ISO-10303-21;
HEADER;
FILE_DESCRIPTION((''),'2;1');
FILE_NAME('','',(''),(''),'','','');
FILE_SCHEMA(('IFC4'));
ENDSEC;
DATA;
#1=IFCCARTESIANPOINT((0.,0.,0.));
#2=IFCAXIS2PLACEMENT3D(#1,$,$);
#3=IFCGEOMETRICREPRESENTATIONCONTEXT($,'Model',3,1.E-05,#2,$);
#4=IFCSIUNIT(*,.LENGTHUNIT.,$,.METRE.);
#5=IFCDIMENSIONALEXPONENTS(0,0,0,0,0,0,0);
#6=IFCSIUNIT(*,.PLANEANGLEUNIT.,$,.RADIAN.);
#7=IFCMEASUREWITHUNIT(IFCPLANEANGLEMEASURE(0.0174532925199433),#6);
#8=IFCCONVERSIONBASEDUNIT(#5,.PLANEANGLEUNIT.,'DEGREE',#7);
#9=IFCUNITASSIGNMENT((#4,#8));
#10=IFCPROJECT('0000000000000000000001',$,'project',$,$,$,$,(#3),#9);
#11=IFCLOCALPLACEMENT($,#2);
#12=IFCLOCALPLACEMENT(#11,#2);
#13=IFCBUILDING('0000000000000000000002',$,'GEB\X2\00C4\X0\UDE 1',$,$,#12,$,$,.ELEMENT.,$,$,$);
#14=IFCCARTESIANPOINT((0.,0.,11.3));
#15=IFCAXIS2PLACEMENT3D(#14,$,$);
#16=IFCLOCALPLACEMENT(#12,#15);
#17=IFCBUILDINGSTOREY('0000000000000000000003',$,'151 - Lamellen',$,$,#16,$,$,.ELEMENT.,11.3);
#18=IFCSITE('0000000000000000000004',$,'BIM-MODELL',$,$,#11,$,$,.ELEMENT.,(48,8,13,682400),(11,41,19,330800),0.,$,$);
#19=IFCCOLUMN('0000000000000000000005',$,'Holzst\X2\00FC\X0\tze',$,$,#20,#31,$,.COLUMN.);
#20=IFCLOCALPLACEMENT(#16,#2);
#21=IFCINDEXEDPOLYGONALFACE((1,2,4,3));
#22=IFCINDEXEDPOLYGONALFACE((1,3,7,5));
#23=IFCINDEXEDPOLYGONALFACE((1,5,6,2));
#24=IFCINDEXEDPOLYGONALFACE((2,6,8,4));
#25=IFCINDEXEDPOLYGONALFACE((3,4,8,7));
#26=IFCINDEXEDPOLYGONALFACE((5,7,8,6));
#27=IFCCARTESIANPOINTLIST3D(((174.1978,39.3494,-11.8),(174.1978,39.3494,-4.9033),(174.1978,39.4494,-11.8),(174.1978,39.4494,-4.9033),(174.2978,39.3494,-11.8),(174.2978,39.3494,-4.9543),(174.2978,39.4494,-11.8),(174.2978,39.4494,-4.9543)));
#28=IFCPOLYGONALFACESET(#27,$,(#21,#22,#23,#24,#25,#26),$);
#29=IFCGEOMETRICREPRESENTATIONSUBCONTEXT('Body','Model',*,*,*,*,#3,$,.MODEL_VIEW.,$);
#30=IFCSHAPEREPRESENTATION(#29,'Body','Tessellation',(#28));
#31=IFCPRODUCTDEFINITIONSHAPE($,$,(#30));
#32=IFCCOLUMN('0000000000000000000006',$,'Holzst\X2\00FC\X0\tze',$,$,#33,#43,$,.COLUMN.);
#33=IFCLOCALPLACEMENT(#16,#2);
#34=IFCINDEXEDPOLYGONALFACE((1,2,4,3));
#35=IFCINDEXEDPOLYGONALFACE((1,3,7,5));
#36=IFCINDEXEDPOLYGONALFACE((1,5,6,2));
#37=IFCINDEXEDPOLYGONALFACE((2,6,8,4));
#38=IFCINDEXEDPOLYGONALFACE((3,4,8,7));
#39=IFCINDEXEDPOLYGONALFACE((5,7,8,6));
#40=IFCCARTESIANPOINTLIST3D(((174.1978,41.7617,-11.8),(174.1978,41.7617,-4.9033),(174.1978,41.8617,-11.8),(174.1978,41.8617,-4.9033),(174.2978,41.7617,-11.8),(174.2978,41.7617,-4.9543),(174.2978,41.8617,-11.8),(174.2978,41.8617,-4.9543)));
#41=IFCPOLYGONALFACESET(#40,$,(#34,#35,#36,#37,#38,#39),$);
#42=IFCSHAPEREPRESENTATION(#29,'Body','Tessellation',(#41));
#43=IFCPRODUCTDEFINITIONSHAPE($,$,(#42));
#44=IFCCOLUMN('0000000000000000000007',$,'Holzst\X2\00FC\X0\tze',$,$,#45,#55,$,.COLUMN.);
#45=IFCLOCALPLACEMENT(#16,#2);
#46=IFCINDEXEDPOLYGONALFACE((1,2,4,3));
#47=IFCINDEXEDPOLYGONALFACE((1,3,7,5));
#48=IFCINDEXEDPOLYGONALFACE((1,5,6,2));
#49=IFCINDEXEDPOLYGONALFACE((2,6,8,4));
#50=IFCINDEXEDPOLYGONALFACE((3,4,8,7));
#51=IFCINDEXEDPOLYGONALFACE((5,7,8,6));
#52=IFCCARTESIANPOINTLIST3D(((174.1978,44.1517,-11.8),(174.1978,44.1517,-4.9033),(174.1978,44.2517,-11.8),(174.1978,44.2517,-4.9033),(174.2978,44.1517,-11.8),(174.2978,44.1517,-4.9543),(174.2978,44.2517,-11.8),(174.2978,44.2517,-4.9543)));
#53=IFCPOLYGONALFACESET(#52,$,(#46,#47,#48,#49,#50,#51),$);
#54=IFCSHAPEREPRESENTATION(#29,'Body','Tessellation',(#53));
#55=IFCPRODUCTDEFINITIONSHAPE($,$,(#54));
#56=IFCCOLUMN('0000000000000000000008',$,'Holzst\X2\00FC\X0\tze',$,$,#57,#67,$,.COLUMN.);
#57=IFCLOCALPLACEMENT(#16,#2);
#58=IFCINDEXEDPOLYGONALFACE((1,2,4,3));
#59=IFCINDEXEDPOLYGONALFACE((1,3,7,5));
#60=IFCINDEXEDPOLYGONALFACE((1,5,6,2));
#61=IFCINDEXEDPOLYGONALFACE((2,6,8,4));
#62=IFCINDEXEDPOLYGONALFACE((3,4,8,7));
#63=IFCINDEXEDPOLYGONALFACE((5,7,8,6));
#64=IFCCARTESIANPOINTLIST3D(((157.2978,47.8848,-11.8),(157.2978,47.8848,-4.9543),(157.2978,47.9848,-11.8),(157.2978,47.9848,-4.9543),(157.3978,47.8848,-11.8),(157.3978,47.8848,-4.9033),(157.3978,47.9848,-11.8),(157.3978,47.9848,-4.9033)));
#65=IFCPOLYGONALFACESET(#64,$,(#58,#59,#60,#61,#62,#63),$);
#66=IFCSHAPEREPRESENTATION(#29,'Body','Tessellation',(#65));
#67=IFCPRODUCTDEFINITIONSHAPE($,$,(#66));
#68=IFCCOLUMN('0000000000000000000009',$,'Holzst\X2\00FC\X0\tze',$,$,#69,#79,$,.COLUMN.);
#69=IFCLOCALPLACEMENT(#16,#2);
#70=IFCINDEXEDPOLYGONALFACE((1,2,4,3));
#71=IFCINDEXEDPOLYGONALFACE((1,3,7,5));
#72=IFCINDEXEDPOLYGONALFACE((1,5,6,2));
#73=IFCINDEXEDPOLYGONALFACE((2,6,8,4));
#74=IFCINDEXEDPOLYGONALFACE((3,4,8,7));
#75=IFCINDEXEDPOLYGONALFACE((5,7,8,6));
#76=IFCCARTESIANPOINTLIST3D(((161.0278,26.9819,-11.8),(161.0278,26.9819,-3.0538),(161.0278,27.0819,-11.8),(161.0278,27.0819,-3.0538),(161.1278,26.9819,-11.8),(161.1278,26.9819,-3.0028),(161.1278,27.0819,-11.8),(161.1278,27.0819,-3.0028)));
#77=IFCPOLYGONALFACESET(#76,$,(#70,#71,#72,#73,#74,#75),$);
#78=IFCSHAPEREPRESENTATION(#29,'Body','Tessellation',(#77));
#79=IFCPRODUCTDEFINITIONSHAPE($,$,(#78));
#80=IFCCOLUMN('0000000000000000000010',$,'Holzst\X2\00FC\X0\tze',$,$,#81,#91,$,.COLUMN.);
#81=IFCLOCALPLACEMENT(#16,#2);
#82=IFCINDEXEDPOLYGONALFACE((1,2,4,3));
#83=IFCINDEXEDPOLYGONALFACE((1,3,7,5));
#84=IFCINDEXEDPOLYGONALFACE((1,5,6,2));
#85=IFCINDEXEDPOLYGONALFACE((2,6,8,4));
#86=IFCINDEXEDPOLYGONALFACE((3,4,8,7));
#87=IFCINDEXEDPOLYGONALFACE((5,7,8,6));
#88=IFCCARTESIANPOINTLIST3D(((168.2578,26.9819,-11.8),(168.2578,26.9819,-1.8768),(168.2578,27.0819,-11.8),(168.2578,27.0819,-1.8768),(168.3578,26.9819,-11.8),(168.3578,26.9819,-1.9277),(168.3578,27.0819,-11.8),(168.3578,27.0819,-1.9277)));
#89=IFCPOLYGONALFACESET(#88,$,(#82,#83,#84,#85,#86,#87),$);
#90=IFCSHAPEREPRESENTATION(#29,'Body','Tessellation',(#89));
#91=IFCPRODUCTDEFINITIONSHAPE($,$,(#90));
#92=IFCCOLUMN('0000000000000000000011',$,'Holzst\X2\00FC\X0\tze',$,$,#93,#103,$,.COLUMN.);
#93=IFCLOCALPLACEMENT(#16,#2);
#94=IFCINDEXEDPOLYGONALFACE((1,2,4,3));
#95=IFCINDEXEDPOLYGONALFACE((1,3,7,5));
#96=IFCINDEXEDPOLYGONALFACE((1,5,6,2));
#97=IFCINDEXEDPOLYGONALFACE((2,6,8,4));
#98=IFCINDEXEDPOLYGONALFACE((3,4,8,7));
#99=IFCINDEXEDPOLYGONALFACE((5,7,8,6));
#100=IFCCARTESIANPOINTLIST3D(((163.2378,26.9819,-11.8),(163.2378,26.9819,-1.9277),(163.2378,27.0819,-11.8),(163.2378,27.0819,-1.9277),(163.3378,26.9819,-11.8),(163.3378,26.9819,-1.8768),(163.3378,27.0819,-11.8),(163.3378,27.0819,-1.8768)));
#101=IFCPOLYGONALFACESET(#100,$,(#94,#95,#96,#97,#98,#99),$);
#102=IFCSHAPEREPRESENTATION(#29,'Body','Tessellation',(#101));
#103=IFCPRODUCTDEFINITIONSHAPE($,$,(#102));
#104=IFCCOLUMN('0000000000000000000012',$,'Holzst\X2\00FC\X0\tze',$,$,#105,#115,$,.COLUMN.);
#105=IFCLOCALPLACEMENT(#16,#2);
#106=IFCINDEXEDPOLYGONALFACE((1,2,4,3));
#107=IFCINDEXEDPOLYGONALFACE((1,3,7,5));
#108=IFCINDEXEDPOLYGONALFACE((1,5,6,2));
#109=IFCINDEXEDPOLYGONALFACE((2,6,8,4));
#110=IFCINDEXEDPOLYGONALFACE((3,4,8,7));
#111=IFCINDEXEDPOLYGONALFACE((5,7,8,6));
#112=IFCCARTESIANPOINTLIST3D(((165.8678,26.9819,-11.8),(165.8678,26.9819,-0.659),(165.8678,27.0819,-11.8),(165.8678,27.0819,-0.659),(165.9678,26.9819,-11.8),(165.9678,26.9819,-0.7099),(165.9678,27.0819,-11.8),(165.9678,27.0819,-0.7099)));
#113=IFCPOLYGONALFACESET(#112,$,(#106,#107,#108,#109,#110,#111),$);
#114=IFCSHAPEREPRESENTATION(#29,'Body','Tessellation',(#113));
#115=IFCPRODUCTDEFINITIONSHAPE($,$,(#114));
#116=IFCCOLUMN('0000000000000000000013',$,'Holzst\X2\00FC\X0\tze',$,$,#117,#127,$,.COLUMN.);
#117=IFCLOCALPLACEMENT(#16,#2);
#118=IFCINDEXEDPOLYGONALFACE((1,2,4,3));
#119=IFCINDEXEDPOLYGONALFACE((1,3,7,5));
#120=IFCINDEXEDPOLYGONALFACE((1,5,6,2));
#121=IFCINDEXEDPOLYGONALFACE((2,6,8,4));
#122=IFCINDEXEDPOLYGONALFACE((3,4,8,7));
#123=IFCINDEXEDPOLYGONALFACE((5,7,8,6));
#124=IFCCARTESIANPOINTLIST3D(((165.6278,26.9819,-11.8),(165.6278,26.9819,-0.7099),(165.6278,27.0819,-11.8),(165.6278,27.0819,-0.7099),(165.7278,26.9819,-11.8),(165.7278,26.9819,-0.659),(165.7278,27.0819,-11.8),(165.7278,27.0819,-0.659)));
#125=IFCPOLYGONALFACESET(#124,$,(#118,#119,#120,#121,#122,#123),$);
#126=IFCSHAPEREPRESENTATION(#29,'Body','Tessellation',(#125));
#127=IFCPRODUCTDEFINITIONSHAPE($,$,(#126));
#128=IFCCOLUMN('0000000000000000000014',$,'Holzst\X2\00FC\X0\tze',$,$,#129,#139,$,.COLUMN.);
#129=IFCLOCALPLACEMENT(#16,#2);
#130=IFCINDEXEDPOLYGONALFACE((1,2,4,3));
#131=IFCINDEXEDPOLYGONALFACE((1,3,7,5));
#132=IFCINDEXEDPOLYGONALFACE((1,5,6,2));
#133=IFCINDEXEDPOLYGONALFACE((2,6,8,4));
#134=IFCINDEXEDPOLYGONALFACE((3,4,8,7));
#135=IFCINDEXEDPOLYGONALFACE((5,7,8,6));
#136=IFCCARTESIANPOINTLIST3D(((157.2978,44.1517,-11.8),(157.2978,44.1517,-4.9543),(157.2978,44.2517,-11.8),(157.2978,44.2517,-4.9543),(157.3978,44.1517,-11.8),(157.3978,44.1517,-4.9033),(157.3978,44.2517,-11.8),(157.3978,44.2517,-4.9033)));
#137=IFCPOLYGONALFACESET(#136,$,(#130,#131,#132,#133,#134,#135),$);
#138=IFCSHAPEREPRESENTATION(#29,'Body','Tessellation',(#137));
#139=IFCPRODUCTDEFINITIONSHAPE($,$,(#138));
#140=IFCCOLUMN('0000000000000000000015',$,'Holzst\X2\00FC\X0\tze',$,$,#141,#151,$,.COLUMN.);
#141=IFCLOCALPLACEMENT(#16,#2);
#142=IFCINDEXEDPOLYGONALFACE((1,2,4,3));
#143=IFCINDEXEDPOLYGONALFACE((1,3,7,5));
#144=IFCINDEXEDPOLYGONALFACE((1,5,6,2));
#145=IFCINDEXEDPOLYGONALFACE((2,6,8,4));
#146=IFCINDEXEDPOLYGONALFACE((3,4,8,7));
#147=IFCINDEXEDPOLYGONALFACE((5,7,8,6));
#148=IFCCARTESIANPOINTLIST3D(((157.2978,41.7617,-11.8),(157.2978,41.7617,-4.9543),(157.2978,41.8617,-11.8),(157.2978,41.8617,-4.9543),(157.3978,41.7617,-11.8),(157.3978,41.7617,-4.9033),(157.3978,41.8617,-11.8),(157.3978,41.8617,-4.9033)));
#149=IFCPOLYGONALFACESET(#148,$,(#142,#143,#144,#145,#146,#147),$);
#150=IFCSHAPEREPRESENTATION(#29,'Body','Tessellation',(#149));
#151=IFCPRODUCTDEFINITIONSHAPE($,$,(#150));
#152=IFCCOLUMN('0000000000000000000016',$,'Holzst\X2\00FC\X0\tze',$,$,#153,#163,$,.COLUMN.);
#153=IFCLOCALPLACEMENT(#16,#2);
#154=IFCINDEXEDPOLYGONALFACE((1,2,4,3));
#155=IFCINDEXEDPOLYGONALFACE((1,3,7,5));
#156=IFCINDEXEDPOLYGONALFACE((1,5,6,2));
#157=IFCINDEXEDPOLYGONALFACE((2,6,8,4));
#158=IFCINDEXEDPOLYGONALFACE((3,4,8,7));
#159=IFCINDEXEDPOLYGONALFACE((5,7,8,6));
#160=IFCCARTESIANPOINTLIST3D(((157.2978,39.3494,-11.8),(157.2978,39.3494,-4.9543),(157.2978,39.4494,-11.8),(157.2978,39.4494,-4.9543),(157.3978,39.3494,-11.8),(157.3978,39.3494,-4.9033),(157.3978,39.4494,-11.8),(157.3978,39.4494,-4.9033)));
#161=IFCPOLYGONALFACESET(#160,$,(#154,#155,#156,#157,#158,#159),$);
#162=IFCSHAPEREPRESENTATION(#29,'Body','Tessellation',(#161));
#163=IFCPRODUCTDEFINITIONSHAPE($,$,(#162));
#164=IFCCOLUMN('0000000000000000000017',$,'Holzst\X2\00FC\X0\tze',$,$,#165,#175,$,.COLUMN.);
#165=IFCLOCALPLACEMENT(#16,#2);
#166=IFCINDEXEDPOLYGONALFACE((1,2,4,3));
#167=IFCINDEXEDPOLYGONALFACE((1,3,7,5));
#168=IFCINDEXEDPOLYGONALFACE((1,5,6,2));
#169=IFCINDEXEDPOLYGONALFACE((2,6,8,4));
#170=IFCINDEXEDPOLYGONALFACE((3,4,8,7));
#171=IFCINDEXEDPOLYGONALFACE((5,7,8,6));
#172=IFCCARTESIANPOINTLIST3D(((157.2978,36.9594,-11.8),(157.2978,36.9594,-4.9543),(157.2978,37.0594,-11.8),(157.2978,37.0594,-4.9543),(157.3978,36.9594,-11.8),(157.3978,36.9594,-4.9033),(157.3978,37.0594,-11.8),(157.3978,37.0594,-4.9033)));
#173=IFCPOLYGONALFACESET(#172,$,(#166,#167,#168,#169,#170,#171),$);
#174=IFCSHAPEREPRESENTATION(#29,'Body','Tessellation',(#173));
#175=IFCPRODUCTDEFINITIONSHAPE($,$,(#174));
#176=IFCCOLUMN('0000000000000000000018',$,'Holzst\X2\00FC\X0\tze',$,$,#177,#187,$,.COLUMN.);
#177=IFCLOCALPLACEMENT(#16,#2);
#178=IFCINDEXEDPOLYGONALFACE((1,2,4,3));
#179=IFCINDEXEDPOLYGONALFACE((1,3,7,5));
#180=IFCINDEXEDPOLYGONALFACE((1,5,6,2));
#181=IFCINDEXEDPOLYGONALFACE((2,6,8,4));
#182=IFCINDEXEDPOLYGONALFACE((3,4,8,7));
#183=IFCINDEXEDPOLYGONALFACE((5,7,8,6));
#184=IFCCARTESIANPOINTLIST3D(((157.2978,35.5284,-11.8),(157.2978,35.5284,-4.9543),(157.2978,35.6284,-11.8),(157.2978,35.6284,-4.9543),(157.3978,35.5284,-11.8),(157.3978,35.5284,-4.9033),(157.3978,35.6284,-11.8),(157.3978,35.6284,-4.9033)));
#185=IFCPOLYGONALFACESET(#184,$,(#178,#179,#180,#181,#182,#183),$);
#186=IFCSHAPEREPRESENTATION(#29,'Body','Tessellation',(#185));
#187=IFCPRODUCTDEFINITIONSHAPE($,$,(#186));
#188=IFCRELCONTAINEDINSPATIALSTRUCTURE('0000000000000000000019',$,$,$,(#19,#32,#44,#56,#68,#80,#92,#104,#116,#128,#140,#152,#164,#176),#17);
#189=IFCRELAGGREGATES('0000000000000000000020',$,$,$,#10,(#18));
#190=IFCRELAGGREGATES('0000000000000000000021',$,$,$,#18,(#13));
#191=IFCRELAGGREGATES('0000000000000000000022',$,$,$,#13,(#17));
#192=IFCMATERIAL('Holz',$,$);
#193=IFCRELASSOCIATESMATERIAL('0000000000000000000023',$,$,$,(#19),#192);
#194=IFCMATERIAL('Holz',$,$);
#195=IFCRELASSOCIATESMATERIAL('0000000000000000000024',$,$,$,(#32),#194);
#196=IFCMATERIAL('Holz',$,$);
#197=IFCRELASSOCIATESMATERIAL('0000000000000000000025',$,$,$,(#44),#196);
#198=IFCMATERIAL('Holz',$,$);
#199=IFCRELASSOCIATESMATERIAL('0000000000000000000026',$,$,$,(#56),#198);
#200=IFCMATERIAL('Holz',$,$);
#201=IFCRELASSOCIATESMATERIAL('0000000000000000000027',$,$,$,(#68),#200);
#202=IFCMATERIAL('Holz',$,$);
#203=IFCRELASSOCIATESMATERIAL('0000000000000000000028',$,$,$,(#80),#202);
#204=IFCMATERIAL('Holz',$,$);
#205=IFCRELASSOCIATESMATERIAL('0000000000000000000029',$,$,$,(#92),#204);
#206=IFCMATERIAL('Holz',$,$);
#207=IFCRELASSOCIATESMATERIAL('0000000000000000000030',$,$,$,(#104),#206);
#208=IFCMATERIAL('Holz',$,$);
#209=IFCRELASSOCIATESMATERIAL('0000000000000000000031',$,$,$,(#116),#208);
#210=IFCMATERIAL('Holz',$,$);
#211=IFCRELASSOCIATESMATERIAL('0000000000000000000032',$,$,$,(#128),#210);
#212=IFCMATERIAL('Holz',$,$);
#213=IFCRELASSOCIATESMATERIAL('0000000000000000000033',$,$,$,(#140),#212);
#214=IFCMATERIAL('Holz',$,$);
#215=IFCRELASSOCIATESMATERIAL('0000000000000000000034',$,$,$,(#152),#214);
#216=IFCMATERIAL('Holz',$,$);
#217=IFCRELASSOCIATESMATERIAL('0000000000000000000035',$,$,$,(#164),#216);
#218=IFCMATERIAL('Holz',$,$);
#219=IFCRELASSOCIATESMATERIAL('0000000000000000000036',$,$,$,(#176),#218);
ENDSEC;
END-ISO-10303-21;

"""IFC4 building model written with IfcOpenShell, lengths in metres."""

from ifc_helpers import new_model, entity, si_unit, converted_unit, frame, frame_2d, origin, origin_with_axes, place, context, subcontext, project, spatial, rectangle, extrude, clip, halfspace, material, element, save


model = new_model("IFC4")

# Units and contexts
model_context = context("Model", 3, precision=1e-05, world=origin())
body_context = subcontext(model_context, "Body", "Model", "MODEL_VIEW")
ifc_project = project(units=[si_unit("LENGTHUNIT", "METRE"), converted_unit("PLANEANGLEUNIT", "DEGREE", entity("IfcPlaneAngleMeasure", 0.0174532925199433), si_unit("PLANEANGLEUNIT", "RADIAN"), dimensions=[0, 0, 0, 0, 0, 0, 0])], contexts=[model_context])

# Site, building, storey
site_placement = place(None, origin())
site = spatial("IfcSite", under=ifc_project, at=site_placement, Name="BIM-MODELL", CompositionType="ELEMENT", RefLatitude=(48, 8, 13, 682400), RefLongitude=(11, 41, 19, 330800), RefElevation=0.0)
building_placement = place(site_placement, origin())
building = spatial("IfcBuilding", under=site, at=building_placement, Name="GEBÄUDE 1", CompositionType="ELEMENT")
storey_placement = place(building_placement, frame((0.0, 0.0, 11.3)))
storey = spatial("IfcBuildingStorey", under=building, at=storey_placement, Name="151 - Lamellen", CompositionType="ELEMENT", Elevation=11.3)

# Columns
ifc_material_1 = material(Name="Holz")
column_1_placement = place(storey_placement, frame((174.2978, 39.3494, -11.8)))
element("IfcColumn", 1, at=column_1_placement, inside=storey, material=ifc_material_1, Name="Holzstütze", PredefinedType="COLUMN", context=body_context, shape_type="Clipping", body=[
    clip(extrude(rectangle(XDim=0.1, YDim=0.1, at=frame_2d((-0.05, 0.05), x_axis=(0.0, 1.0))), origin_with_axes(), (0.0, 0.0, 1.0), 6.8967), halfspace(frame((-0.05, 0.05, 6.8712), z_axis=(-0.45399, 0.0, -0.891007), x_axis=(0.891007, 0.0, -0.45399)), True)),
])
ifc_material_2 = material(Name="Holz")
column_2_placement = place(storey_placement, frame((174.2978, 41.7617, -11.8)))
element("IfcColumn", 2, at=column_2_placement, inside=storey, material=ifc_material_2, Name="Holzstütze", PredefinedType="COLUMN", context=body_context, shape_type="Clipping", body=[
    clip(extrude(rectangle(XDim=0.1, YDim=0.1, at=frame_2d((-0.05, 0.05), x_axis=(0.0, 1.0))), origin_with_axes(), (0.0, 0.0, 1.0), 6.8967), halfspace(frame((-0.05, 0.05, 6.8712), z_axis=(-0.45399, 0.0, -0.891007), x_axis=(0.891007, 0.0, -0.45399)), True)),
])
ifc_material_3 = material(Name="Holz")
column_3_placement = place(storey_placement, frame((174.2978, 44.1517, -11.8)))
element("IfcColumn", 3, at=column_3_placement, inside=storey, material=ifc_material_3, Name="Holzstütze", PredefinedType="COLUMN", context=body_context, shape_type="Clipping", body=[
    clip(extrude(rectangle(XDim=0.1, YDim=0.1, at=frame_2d((-0.05, 0.05), x_axis=(0.0, 1.0))), origin_with_axes(), (0.0, 0.0, 1.0), 6.8967), halfspace(frame((-0.05, 0.05, 6.8712), z_axis=(-0.45399, 0.0, -0.891007), x_axis=(0.891007, 0.0, -0.45399)), True)),
])
ifc_material_4 = material(Name="Holz")
column_4_placement = place(storey_placement, frame((157.3978, 47.8848, -11.8)))
element("IfcColumn", 4, at=column_4_placement, inside=storey, material=ifc_material_4, Name="Holzstütze", PredefinedType="COLUMN", context=body_context, shape_type="Clipping", body=[
    clip(extrude(rectangle(XDim=0.1, YDim=0.1, at=frame_2d((-0.05, 0.05), x_axis=(0.0, 1.0))), origin_with_axes(), (0.0, 0.0, 1.0), 6.8967), halfspace(frame((-0.05, 0.05, 6.8712), z_axis=(0.45399, 0.0, -0.891007), x_axis=(0.0, 1.0, 0.0)), True)),
])
ifc_material_5 = material(Name="Holz")
column_5_placement = place(storey_placement, frame((161.1278, 26.9819, -11.8)))
element("IfcColumn", 5, at=column_5_placement, inside=storey, material=ifc_material_5, Name="Holzstütze", PredefinedType="COLUMN", context=body_context, shape_type="Clipping", body=[
    clip(extrude(rectangle(XDim=0.1, YDim=0.1, at=frame_2d((-0.05, 0.05), x_axis=(0.0, 1.0))), origin_with_axes(), (0.0, 0.0, 1.0), 8.7972), halfspace(frame((-0.05, 0.05, 8.7717), z_axis=(0.45399, 0.0, -0.891007), x_axis=(0.0, -1.0, 0.0)), True)),
])
ifc_material_6 = material(Name="Holz")
column_6_placement = place(storey_placement, frame((168.3578, 26.9819, -11.8)))
element("IfcColumn", 6, at=column_6_placement, inside=storey, material=ifc_material_6, Name="Holzstütze", PredefinedType="COLUMN", context=body_context, shape_type="Clipping", body=[
    clip(extrude(rectangle(XDim=0.1, YDim=0.1, at=frame_2d((-0.05, 0.05), x_axis=(0.0, 1.0))), origin_with_axes(), (0.0, 0.0, 1.0), 9.9232), halfspace(frame((-0.05, 0.05, 9.8978), z_axis=(-0.45399, 0.0, -0.891007), x_axis=(0.0, -1.0, 0.0)), True)),
])
ifc_material_7 = material(Name="Holz")
column_7_placement = place(storey_placement, frame((163.3378, 26.9819, -11.8)))
element("IfcColumn", 7, at=column_7_placement, inside=storey, material=ifc_material_7, Name="Holzstütze", PredefinedType="COLUMN", context=body_context, shape_type="Clipping", body=[
    clip(extrude(rectangle(XDim=0.1, YDim=0.1, at=frame_2d((-0.05, 0.05), x_axis=(0.0, 1.0))), origin_with_axes(), (0.0, 0.0, 1.0), 9.9232), halfspace(frame((-0.05, 0.05, 9.8978), z_axis=(0.45399, 0.0, -0.891007), x_axis=(0.0, -1.0, 0.0)), True)),
])
ifc_material_8 = material(Name="Holz")
column_8_placement = place(storey_placement, frame((165.9678, 26.9819, -11.8)))
element("IfcColumn", 8, at=column_8_placement, inside=storey, material=ifc_material_8, Name="Holzstütze", PredefinedType="COLUMN", context=body_context, shape_type="Clipping", body=[
    clip(extrude(rectangle(XDim=0.1, YDim=0.1, at=frame_2d((-0.05, 0.05), x_axis=(0.0, 1.0))), origin_with_axes(), (0.0, 0.0, 1.0), 11.141), halfspace(frame((-0.05, 0.05, 11.1155), z_axis=(-0.45399, 0.0, -0.891007), x_axis=(0.0, -1.0, 0.0)), True)),
])
ifc_material_9 = material(Name="Holz")
column_9_placement = place(storey_placement, frame((165.7278, 26.9819, -11.8)))
element("IfcColumn", 9, at=column_9_placement, inside=storey, material=ifc_material_9, Name="Holzstütze", PredefinedType="COLUMN", context=body_context, shape_type="Clipping", body=[
    clip(extrude(rectangle(XDim=0.1, YDim=0.1, at=frame_2d((-0.05, 0.05), x_axis=(0.0, 1.0))), origin_with_axes(), (0.0, 0.0, 1.0), 11.141), halfspace(frame((-0.05, 0.05, 11.1155), z_axis=(0.45399, 0.0, -0.891007), x_axis=(0.0, -1.0, 0.0)), True)),
])
ifc_material_10 = material(Name="Holz")
column_10_placement = place(storey_placement, frame((157.3978, 44.1517, -11.8)))
element("IfcColumn", 10, at=column_10_placement, inside=storey, material=ifc_material_10, Name="Holzstütze", PredefinedType="COLUMN", context=body_context, shape_type="Clipping", body=[
    clip(extrude(rectangle(XDim=0.1, YDim=0.1, at=frame_2d((-0.05, 0.05), x_axis=(0.0, 1.0))), origin_with_axes(), (0.0, 0.0, 1.0), 6.8967), halfspace(frame((-0.05, 0.05, 6.8712), z_axis=(0.45399, 0.0, -0.891007), x_axis=(-0.891007, 0.0, -0.45399)), True)),
])
ifc_material_11 = material(Name="Holz")
column_11_placement = place(storey_placement, frame((157.3978, 41.7617, -11.8)))
element("IfcColumn", 11, at=column_11_placement, inside=storey, material=ifc_material_11, Name="Holzstütze", PredefinedType="COLUMN", context=body_context, shape_type="Clipping", body=[
    clip(extrude(rectangle(XDim=0.1, YDim=0.1, at=frame_2d((-0.05, 0.05), x_axis=(0.0, 1.0))), origin_with_axes(), (0.0, 0.0, 1.0), 6.8967), halfspace(frame((-0.05, 0.05, 6.8712), z_axis=(0.45399, 0.0, -0.891007), x_axis=(-0.891007, 0.0, -0.45399)), True)),
])
ifc_material_12 = material(Name="Holz")
column_12_placement = place(storey_placement, frame((157.3978, 39.3494, -11.8)))
element("IfcColumn", 12, at=column_12_placement, inside=storey, material=ifc_material_12, Name="Holzstütze", PredefinedType="COLUMN", context=body_context, shape_type="Clipping", body=[
    clip(extrude(rectangle(XDim=0.1, YDim=0.1, at=frame_2d((-0.05, 0.05), x_axis=(0.0, 1.0))), origin_with_axes(), (0.0, 0.0, 1.0), 6.8967), halfspace(frame((-0.05, 0.05, 6.8712), z_axis=(0.45399, 0.0, -0.891007), x_axis=(-0.891007, 0.0, -0.45399)), True)),
])
ifc_material_13 = material(Name="Holz")
column_13_placement = place(storey_placement, frame((157.3978, 36.9594, -11.8)))
element("IfcColumn", 13, at=column_13_placement, inside=storey, material=ifc_material_13, Name="Holzstütze", PredefinedType="COLUMN", context=body_context, shape_type="Clipping", body=[
    clip(extrude(rectangle(XDim=0.1, YDim=0.1, at=frame_2d((-0.05, 0.05), x_axis=(0.0, 1.0))), origin_with_axes(), (0.0, 0.0, 1.0), 6.8967), halfspace(frame((-0.05, 0.05, 6.8712), z_axis=(0.45399, 0.0, -0.891007), x_axis=(-0.891007, 0.0, -0.45399)), True)),
])
ifc_material_14 = material(Name="Holz")
column_14_placement = place(storey_placement, frame((157.3978, 35.5284, -11.8)))
element("IfcColumn", 14, at=column_14_placement, inside=storey, material=ifc_material_14, Name="Holzstütze", PredefinedType="COLUMN", context=body_context, shape_type="Clipping", body=[
    clip(extrude(rectangle(XDim=0.1, YDim=0.1, at=frame_2d((-0.05, 0.05), x_axis=(0.0, 1.0))), origin_with_axes(), (0.0, 0.0, 1.0), 6.8967), halfspace(frame((-0.05, 0.05, 6.8712), z_axis=(0.45399, 0.0, -0.891007), x_axis=(-0.891007, 0.0, -0.45399)), True)),
])

save(model, "model.ifc")
